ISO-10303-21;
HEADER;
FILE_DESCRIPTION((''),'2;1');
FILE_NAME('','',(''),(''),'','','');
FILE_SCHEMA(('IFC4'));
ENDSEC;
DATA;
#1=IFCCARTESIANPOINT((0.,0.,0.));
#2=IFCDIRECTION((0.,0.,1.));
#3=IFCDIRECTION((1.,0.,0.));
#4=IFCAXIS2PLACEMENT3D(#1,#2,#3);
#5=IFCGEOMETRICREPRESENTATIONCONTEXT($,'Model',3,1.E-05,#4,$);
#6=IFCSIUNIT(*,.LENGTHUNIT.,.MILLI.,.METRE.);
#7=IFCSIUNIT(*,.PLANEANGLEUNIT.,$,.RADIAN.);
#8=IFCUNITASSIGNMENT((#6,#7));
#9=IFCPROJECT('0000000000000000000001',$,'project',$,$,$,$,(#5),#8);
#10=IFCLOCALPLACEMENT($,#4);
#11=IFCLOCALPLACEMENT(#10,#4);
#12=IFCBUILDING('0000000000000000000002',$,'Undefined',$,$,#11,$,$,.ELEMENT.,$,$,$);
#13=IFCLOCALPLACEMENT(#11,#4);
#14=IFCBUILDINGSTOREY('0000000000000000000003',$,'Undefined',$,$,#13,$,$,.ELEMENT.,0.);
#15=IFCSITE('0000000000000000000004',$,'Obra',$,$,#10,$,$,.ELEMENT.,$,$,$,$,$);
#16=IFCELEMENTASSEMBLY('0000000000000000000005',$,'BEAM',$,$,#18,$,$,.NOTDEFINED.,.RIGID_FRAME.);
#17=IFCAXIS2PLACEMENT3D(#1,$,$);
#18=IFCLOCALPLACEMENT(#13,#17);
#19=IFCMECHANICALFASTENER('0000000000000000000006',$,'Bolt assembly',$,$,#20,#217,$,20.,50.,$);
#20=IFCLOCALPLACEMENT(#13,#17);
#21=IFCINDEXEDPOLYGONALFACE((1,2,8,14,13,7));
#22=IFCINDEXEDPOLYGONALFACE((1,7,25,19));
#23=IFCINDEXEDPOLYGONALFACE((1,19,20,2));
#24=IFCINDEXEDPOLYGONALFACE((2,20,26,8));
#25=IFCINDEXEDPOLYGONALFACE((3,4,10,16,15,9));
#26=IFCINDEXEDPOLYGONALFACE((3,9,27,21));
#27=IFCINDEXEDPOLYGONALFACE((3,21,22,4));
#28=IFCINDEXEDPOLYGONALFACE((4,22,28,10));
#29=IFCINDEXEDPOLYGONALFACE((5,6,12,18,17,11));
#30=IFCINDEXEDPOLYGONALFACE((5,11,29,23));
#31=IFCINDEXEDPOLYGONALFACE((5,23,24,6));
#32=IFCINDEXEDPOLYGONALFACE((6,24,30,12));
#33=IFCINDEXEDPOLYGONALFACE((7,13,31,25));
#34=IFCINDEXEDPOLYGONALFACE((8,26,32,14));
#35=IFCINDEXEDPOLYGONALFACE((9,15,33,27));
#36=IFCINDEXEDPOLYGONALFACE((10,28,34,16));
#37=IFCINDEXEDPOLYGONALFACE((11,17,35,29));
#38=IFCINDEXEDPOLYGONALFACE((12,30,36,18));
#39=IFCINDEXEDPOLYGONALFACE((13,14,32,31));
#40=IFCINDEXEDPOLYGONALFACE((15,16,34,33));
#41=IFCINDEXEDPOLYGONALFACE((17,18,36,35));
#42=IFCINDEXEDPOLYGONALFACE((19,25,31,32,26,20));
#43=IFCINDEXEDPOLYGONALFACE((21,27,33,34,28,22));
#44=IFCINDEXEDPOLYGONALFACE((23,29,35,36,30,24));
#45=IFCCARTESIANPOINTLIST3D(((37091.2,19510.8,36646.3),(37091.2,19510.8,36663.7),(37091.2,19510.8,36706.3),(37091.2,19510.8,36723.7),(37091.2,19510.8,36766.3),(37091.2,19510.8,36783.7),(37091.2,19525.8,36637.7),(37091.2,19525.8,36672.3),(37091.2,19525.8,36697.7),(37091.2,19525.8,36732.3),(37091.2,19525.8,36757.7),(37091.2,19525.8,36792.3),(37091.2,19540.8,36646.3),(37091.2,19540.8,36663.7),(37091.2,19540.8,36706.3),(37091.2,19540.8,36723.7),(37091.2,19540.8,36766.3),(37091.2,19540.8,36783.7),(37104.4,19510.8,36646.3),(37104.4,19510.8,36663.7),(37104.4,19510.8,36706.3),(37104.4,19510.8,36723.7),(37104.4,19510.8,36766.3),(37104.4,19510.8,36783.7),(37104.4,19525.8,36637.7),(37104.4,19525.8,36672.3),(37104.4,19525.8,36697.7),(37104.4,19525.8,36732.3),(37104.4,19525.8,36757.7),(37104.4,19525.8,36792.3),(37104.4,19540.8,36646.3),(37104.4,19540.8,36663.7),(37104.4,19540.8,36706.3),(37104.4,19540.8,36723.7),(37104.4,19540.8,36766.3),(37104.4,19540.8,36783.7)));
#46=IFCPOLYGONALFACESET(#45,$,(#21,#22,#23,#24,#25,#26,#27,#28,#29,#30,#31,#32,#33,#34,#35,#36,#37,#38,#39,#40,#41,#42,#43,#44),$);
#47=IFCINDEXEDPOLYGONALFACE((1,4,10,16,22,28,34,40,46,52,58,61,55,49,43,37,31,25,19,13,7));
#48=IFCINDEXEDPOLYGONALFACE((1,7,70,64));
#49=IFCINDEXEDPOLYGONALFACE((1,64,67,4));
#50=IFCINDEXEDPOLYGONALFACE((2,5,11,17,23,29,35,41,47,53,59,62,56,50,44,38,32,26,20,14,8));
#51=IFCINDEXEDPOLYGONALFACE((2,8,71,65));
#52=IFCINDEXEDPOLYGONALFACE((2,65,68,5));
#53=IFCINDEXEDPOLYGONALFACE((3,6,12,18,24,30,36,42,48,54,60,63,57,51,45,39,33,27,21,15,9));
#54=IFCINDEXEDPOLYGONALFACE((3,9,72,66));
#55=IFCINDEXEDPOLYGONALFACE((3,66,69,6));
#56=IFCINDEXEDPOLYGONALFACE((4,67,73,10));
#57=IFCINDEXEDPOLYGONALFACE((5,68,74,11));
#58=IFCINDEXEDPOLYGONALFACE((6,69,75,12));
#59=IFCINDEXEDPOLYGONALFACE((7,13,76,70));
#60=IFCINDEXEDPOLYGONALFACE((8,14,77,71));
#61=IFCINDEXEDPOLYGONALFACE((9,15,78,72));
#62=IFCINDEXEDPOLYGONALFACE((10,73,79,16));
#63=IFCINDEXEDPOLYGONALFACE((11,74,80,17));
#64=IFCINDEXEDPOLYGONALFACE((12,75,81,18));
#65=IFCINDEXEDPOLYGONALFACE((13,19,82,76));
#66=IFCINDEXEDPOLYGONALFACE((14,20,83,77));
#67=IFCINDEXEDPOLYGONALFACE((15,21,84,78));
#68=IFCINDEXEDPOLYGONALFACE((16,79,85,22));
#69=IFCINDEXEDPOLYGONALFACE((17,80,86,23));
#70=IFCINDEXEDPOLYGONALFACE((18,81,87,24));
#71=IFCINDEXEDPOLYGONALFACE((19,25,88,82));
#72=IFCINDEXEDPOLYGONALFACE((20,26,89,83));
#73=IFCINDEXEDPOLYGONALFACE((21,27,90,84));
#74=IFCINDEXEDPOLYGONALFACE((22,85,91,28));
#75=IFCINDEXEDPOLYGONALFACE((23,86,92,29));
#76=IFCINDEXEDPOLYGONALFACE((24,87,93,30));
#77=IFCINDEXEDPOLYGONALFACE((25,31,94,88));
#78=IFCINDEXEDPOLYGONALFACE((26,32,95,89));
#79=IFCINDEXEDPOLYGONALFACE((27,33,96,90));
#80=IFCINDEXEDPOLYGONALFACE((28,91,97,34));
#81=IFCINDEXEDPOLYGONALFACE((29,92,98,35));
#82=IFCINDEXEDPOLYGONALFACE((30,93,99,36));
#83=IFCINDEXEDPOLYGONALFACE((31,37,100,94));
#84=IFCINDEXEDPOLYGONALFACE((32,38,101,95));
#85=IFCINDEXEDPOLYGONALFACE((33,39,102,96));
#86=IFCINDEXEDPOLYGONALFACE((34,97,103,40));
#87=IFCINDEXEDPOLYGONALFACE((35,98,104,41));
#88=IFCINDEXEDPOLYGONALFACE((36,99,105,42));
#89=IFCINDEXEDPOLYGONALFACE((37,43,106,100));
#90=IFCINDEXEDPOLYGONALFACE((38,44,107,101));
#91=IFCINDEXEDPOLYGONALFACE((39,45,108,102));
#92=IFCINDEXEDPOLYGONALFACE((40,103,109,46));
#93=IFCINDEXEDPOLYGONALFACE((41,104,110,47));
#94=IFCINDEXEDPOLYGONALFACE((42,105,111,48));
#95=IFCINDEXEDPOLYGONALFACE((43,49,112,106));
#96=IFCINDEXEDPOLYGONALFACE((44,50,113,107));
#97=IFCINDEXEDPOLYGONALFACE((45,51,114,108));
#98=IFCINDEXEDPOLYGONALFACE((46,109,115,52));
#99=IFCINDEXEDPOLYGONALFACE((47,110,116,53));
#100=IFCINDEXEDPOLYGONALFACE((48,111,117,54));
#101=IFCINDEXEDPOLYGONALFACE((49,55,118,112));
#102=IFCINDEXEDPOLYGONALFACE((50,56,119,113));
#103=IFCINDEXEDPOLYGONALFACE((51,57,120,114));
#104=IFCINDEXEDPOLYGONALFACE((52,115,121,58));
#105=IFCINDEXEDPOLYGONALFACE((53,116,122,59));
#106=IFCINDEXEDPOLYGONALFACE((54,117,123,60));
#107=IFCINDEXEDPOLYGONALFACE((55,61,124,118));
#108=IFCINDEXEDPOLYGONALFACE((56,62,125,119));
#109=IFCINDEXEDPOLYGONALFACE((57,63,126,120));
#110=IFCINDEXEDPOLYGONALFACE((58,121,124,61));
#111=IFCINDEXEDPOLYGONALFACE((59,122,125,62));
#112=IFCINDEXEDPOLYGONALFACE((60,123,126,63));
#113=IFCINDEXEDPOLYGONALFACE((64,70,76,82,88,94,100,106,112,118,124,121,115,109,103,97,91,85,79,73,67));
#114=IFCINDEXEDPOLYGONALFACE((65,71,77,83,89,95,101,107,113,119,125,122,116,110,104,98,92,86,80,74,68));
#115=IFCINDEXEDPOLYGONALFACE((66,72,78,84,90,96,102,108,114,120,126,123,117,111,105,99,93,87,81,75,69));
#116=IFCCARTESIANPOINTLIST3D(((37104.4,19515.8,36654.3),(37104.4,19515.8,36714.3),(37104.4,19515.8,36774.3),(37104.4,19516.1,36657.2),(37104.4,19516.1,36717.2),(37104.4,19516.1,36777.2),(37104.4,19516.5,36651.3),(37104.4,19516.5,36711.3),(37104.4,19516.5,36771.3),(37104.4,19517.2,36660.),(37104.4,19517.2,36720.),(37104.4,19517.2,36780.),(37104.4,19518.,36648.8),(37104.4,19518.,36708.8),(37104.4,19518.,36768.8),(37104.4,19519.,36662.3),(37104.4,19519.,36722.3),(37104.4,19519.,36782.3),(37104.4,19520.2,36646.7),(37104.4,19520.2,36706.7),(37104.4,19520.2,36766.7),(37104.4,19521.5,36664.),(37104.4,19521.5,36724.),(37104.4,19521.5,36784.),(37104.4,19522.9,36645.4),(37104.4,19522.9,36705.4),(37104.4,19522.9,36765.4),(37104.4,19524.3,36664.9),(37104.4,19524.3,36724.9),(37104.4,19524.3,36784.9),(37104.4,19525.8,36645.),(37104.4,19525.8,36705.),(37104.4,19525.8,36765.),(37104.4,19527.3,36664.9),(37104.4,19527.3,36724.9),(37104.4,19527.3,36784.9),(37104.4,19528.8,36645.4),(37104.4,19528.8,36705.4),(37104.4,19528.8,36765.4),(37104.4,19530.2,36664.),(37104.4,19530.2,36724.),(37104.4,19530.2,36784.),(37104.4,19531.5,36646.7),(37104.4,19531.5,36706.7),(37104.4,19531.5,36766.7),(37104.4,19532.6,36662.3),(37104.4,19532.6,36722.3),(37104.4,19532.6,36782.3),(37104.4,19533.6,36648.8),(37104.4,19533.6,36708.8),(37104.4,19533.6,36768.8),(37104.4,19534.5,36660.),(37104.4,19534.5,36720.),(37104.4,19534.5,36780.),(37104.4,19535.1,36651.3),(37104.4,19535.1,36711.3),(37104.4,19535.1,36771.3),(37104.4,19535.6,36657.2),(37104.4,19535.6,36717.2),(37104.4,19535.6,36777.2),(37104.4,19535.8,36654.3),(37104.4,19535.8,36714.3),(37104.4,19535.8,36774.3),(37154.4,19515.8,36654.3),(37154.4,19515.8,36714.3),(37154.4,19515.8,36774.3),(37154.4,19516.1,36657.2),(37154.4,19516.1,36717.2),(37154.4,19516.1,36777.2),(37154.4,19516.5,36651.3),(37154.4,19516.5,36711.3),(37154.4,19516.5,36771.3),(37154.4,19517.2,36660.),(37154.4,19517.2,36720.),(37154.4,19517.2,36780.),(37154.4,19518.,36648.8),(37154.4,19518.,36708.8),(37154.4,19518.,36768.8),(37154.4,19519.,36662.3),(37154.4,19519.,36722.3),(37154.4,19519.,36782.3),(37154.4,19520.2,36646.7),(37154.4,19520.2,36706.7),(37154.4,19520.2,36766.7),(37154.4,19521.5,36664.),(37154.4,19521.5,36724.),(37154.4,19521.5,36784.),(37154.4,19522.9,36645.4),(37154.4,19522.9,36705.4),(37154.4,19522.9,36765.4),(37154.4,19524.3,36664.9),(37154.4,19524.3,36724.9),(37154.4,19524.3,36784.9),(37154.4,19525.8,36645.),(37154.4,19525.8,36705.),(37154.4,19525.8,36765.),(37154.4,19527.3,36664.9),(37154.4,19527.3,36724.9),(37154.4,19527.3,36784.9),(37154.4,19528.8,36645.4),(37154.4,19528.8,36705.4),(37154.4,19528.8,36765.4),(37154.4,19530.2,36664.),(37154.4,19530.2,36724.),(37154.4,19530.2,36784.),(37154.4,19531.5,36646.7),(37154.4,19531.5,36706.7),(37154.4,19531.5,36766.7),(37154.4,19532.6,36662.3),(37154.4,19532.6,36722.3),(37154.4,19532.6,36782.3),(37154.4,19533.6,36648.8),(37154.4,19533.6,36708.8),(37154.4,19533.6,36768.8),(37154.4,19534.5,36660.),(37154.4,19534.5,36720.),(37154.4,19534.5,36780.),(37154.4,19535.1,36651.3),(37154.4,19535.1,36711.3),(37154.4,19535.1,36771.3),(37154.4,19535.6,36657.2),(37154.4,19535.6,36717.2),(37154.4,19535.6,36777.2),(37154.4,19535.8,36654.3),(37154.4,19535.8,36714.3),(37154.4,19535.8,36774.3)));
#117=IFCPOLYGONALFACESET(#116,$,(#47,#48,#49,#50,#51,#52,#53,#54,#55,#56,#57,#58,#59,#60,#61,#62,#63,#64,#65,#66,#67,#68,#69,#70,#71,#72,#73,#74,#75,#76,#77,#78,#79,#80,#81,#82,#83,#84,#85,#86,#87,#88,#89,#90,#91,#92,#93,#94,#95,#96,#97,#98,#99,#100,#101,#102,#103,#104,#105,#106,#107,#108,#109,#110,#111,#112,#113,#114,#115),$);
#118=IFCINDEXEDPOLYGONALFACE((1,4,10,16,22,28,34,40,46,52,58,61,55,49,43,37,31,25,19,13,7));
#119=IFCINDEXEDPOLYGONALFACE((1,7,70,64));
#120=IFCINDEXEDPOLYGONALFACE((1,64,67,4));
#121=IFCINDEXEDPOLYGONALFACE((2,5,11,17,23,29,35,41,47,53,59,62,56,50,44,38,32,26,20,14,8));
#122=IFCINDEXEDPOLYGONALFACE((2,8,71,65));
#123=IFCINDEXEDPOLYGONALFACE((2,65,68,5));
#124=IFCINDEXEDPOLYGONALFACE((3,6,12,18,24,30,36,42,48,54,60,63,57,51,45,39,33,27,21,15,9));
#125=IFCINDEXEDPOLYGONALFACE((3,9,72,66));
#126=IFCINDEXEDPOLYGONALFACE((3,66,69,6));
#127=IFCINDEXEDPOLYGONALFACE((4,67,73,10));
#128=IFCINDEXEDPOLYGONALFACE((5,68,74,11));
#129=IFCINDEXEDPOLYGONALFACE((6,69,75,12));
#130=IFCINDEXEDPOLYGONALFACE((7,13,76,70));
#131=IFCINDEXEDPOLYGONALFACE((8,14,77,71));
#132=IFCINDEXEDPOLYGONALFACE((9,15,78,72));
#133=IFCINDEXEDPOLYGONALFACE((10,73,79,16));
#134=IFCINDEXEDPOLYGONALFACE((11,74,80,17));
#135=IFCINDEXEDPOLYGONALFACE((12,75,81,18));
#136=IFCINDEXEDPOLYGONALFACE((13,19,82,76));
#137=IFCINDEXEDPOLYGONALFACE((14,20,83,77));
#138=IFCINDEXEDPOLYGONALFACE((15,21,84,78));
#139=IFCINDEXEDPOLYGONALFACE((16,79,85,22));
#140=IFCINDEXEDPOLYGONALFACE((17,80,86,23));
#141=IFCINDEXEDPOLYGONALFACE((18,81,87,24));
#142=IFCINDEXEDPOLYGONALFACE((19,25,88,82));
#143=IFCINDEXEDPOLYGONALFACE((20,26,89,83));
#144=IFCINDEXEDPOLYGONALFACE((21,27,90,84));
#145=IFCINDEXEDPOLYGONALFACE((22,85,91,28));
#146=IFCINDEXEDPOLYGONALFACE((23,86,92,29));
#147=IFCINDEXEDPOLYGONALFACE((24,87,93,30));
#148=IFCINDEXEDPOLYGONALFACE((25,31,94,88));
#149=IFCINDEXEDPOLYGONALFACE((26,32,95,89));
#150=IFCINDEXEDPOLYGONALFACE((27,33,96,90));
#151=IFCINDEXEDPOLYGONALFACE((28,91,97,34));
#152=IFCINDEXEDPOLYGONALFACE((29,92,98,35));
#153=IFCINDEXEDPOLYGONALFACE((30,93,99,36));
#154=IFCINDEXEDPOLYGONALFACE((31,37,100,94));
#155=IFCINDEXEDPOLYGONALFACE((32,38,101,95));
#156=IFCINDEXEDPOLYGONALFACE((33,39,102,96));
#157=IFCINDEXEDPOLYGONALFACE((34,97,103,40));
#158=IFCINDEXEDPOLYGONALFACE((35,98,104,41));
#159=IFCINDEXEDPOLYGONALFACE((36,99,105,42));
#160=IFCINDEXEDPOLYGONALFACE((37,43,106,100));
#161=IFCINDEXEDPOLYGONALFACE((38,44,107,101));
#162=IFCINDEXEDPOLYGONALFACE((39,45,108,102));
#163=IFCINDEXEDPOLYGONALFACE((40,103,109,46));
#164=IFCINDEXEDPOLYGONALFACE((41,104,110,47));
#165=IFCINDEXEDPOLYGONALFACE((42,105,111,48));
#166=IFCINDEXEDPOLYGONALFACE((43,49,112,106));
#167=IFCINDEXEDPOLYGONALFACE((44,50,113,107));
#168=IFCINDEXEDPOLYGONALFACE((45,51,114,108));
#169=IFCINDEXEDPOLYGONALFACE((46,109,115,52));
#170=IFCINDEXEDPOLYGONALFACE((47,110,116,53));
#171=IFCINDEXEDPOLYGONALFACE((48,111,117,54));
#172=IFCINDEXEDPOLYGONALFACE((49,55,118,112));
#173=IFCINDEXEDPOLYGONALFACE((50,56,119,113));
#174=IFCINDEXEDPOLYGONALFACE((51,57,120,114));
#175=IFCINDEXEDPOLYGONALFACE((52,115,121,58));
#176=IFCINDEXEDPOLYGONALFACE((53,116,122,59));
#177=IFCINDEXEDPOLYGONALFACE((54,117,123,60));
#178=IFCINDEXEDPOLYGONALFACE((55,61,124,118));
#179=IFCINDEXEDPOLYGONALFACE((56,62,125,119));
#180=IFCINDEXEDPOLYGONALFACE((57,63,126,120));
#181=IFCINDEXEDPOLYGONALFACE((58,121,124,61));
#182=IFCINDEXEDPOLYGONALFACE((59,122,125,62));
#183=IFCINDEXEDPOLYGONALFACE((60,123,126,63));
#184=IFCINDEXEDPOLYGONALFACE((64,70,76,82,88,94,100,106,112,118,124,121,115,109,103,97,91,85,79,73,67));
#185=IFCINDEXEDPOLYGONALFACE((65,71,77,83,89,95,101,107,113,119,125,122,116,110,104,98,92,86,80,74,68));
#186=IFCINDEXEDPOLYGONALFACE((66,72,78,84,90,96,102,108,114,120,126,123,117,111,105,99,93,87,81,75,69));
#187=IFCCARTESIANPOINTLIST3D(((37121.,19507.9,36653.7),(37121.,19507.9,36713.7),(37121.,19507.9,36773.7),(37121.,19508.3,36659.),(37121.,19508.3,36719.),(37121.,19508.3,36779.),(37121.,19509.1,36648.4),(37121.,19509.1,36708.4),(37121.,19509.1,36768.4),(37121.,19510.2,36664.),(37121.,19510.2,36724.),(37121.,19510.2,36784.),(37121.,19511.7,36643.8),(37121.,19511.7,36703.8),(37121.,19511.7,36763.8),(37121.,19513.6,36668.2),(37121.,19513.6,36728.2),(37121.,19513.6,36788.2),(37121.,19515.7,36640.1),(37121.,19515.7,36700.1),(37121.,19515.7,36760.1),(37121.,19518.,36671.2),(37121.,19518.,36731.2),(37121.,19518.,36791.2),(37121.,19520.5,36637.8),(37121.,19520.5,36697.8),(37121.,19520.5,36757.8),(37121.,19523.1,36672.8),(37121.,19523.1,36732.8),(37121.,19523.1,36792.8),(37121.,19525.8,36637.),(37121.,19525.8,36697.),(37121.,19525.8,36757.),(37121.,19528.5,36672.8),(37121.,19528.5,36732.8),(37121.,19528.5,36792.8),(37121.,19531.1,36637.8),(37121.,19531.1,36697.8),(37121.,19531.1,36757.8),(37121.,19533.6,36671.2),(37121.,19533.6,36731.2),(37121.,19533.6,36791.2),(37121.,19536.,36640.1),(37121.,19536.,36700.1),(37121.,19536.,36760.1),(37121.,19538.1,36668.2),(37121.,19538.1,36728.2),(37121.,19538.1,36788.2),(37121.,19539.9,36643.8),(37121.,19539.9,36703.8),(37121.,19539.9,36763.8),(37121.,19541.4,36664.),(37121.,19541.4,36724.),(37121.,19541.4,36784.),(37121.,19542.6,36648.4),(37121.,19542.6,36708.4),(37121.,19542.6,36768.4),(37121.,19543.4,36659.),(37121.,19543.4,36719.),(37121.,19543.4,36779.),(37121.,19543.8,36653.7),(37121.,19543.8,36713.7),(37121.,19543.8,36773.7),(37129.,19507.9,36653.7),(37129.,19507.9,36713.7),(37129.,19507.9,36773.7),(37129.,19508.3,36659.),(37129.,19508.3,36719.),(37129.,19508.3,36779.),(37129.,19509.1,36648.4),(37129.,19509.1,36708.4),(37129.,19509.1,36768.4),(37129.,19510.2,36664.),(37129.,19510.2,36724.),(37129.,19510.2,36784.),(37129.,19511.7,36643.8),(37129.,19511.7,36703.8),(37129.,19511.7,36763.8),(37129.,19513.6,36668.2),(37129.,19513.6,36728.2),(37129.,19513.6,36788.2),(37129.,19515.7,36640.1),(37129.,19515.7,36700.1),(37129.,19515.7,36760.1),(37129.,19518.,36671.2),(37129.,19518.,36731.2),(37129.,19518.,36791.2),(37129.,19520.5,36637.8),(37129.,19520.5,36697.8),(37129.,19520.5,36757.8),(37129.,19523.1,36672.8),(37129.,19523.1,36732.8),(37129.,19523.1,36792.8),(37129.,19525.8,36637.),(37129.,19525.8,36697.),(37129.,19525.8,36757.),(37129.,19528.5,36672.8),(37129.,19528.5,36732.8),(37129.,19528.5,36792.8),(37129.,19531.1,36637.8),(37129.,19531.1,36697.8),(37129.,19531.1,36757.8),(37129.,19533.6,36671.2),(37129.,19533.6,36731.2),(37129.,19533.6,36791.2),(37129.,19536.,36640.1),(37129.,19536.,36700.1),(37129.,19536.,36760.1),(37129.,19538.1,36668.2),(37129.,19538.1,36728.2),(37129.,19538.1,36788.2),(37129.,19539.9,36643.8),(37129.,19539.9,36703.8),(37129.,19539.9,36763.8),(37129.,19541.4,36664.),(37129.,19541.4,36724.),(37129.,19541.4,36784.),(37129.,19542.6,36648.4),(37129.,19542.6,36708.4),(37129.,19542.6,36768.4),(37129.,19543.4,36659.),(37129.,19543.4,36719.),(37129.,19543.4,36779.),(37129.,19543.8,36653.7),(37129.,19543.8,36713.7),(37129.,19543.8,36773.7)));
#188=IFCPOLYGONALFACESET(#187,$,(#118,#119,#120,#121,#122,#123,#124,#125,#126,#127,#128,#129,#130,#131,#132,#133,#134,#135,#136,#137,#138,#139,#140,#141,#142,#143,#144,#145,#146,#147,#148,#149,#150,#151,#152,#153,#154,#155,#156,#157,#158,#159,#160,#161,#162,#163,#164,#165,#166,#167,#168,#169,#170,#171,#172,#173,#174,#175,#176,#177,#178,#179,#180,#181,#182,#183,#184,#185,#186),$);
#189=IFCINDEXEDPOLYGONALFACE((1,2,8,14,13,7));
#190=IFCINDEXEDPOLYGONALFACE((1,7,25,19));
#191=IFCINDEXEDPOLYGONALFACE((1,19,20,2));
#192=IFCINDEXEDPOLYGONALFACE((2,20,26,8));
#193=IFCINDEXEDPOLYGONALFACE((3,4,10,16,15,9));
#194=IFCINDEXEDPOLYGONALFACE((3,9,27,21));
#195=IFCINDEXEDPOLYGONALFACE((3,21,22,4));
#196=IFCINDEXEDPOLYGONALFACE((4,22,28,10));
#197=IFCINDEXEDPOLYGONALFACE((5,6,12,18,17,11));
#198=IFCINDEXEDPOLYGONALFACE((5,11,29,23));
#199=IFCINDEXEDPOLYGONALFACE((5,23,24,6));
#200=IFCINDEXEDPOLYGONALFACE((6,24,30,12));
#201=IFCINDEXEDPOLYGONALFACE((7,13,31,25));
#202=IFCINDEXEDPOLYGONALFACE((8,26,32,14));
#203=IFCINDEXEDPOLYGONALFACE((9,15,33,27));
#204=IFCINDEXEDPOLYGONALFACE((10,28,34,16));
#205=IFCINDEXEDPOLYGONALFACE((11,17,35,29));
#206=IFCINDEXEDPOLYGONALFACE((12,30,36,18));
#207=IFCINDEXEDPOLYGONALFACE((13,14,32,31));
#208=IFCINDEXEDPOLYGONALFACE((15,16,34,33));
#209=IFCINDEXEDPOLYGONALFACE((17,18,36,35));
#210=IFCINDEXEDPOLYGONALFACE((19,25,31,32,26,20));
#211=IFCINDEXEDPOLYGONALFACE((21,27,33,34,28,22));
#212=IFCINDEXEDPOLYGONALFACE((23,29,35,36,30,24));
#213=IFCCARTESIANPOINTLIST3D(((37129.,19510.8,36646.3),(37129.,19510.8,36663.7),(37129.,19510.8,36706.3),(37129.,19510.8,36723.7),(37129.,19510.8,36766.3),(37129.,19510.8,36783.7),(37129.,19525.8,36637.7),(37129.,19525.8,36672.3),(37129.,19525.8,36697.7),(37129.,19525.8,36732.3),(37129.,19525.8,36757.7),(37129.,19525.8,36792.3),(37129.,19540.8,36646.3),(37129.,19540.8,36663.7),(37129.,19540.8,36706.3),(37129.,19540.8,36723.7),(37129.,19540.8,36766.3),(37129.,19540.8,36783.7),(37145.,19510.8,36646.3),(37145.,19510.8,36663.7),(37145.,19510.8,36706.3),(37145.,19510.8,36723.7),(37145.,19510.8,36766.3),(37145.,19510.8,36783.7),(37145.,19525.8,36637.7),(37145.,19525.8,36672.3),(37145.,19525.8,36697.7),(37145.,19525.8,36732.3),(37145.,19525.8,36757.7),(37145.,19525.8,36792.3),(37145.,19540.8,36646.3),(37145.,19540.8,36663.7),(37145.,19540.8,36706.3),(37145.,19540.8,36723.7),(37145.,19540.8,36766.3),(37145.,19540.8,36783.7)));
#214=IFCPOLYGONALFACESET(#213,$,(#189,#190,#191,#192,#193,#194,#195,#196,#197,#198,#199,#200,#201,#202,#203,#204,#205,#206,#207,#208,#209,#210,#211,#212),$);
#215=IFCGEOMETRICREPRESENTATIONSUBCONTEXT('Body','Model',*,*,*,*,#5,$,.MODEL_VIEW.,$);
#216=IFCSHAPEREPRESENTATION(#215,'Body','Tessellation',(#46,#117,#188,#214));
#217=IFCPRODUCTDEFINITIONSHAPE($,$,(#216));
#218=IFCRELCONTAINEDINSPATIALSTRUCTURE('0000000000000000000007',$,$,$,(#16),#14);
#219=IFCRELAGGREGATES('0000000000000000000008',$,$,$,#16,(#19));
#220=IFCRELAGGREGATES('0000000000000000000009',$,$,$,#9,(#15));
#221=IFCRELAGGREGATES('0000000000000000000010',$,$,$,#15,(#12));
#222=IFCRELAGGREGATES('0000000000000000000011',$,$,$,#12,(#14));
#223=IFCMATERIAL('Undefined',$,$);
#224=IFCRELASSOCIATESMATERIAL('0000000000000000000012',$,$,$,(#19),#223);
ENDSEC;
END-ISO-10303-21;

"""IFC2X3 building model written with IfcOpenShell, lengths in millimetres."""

from ifc_helpers import new_model, si_unit, frame, origin_with_axes, origin_2d_with_axis, place, context, subcontext, project, spatial, polyline, circle, outline, extrude, source, transform, mapped, material, element, aggregate, save


model = new_model("IFC2X3")

# Units and contexts
model_context = context("Model", 3, precision=1e-05, world=origin_with_axes())
body_context = subcontext(model_context, "Body", "Model", "MODEL_VIEW")
ifc_project = project(units=[si_unit("LENGTHUNIT", "METRE", prefix="MILLI"), si_unit("PLANEANGLEUNIT", "RADIAN")], contexts=[model_context])

# Site, building, storey
site_placement = place(None, origin_with_axes())
site = spatial("IfcSite", under=ifc_project, at=site_placement, Name="Obra", CompositionType="ELEMENT")
building_placement = place(site_placement, origin_with_axes())
building = spatial("IfcBuilding", under=site, at=building_placement, Name="Undefined", CompositionType="ELEMENT")
storey_placement = place(building_placement, origin_with_axes())
storey = spatial("IfcBuildingStorey", under=building, at=storey_placement, Name="Undefined", CompositionType="ELEMENT", Elevation=0.0)

# Element assembly
assembly_1_placement = place(storey_placement, origin_with_axes())
assembly_1 = element("IfcElementAssembly", 1, at=assembly_1_placement, inside=storey, Name="BEAM", AssemblyPlace="NOTDEFINED", PredefinedType="RIGID_FRAME")

# Mechanical fastener
ifc_material_1 = material(Name="Undefined")
shared_shape_1 = source(origin_with_axes(), body_context, "Body", "SweptSolid", [
    extrude(outline(polyline([(17.3, 0.0), (8.7, 15.0), (-8.7, 15.0), (-17.3, 0.0), (-8.7, -15.0), (8.7, -15.0), (17.3, 0.0)])), frame((0.0, -26.5, 0.0), z_axis=(0.0, 1.0, 0.0), x_axis=(1.0, 0.0, 0.0)), (0.0, 0.0, 1.0), 13.2),
    extrude(circle(Radius=10.0, at=origin_2d_with_axis()), frame((0.0, -13.3, 0.0), z_axis=(0.0, 1.0, 0.0), x_axis=(1.0, 0.0, 0.0)), (0.0, 0.0, 1.0), 50.0),
    extrude(circle(Radius=18.0, at=origin_2d_with_axis()), frame((0.0, 3.3, 0.0), z_axis=(0.0, 1.0, 0.0), x_axis=(1.0, 0.0, 0.0)), (0.0, 0.0, 1.0), 8.0),
    extrude(outline(polyline([(17.3, 0.0), (8.7, 15.0), (-8.7, 15.0), (-17.3, 0.0), (-8.7, -15.0), (8.7, -15.0), (17.3, 0.0)])), frame((0.0, 11.3, 0.0), z_axis=(0.0, 1.0, 0.0), x_axis=(1.0, 0.0, 0.0)), (0.0, 0.0, 1.0), 16.0),
])
mechanical_fastener_1_placement = place(assembly_1_placement, frame((37117.7, 19575.8, 36815.0), z_axis=(0.0, -1.0, 0.0), x_axis=(0.0, 0.0, -1.0)))
mechanical_fastener_1 = element("IfcMechanicalFastener", 2, at=mechanical_fastener_1_placement, material=ifc_material_1, Name="Bolt assembly", NominalDiameter=20.0, NominalLength=50.0, context=body_context, shape_type="MappedRepresentation", body=[
    mapped(shared_shape_1, transform((40.0, 0.0, 50.0))),
    mapped(shared_shape_1, transform((100.0, 0.0, 50.0))),
    mapped(shared_shape_1, transform((160.0, 0.0, 50.0))),
])
aggregate(assembly_1, [mechanical_fastener_1])

save(model, "model.ifc")
